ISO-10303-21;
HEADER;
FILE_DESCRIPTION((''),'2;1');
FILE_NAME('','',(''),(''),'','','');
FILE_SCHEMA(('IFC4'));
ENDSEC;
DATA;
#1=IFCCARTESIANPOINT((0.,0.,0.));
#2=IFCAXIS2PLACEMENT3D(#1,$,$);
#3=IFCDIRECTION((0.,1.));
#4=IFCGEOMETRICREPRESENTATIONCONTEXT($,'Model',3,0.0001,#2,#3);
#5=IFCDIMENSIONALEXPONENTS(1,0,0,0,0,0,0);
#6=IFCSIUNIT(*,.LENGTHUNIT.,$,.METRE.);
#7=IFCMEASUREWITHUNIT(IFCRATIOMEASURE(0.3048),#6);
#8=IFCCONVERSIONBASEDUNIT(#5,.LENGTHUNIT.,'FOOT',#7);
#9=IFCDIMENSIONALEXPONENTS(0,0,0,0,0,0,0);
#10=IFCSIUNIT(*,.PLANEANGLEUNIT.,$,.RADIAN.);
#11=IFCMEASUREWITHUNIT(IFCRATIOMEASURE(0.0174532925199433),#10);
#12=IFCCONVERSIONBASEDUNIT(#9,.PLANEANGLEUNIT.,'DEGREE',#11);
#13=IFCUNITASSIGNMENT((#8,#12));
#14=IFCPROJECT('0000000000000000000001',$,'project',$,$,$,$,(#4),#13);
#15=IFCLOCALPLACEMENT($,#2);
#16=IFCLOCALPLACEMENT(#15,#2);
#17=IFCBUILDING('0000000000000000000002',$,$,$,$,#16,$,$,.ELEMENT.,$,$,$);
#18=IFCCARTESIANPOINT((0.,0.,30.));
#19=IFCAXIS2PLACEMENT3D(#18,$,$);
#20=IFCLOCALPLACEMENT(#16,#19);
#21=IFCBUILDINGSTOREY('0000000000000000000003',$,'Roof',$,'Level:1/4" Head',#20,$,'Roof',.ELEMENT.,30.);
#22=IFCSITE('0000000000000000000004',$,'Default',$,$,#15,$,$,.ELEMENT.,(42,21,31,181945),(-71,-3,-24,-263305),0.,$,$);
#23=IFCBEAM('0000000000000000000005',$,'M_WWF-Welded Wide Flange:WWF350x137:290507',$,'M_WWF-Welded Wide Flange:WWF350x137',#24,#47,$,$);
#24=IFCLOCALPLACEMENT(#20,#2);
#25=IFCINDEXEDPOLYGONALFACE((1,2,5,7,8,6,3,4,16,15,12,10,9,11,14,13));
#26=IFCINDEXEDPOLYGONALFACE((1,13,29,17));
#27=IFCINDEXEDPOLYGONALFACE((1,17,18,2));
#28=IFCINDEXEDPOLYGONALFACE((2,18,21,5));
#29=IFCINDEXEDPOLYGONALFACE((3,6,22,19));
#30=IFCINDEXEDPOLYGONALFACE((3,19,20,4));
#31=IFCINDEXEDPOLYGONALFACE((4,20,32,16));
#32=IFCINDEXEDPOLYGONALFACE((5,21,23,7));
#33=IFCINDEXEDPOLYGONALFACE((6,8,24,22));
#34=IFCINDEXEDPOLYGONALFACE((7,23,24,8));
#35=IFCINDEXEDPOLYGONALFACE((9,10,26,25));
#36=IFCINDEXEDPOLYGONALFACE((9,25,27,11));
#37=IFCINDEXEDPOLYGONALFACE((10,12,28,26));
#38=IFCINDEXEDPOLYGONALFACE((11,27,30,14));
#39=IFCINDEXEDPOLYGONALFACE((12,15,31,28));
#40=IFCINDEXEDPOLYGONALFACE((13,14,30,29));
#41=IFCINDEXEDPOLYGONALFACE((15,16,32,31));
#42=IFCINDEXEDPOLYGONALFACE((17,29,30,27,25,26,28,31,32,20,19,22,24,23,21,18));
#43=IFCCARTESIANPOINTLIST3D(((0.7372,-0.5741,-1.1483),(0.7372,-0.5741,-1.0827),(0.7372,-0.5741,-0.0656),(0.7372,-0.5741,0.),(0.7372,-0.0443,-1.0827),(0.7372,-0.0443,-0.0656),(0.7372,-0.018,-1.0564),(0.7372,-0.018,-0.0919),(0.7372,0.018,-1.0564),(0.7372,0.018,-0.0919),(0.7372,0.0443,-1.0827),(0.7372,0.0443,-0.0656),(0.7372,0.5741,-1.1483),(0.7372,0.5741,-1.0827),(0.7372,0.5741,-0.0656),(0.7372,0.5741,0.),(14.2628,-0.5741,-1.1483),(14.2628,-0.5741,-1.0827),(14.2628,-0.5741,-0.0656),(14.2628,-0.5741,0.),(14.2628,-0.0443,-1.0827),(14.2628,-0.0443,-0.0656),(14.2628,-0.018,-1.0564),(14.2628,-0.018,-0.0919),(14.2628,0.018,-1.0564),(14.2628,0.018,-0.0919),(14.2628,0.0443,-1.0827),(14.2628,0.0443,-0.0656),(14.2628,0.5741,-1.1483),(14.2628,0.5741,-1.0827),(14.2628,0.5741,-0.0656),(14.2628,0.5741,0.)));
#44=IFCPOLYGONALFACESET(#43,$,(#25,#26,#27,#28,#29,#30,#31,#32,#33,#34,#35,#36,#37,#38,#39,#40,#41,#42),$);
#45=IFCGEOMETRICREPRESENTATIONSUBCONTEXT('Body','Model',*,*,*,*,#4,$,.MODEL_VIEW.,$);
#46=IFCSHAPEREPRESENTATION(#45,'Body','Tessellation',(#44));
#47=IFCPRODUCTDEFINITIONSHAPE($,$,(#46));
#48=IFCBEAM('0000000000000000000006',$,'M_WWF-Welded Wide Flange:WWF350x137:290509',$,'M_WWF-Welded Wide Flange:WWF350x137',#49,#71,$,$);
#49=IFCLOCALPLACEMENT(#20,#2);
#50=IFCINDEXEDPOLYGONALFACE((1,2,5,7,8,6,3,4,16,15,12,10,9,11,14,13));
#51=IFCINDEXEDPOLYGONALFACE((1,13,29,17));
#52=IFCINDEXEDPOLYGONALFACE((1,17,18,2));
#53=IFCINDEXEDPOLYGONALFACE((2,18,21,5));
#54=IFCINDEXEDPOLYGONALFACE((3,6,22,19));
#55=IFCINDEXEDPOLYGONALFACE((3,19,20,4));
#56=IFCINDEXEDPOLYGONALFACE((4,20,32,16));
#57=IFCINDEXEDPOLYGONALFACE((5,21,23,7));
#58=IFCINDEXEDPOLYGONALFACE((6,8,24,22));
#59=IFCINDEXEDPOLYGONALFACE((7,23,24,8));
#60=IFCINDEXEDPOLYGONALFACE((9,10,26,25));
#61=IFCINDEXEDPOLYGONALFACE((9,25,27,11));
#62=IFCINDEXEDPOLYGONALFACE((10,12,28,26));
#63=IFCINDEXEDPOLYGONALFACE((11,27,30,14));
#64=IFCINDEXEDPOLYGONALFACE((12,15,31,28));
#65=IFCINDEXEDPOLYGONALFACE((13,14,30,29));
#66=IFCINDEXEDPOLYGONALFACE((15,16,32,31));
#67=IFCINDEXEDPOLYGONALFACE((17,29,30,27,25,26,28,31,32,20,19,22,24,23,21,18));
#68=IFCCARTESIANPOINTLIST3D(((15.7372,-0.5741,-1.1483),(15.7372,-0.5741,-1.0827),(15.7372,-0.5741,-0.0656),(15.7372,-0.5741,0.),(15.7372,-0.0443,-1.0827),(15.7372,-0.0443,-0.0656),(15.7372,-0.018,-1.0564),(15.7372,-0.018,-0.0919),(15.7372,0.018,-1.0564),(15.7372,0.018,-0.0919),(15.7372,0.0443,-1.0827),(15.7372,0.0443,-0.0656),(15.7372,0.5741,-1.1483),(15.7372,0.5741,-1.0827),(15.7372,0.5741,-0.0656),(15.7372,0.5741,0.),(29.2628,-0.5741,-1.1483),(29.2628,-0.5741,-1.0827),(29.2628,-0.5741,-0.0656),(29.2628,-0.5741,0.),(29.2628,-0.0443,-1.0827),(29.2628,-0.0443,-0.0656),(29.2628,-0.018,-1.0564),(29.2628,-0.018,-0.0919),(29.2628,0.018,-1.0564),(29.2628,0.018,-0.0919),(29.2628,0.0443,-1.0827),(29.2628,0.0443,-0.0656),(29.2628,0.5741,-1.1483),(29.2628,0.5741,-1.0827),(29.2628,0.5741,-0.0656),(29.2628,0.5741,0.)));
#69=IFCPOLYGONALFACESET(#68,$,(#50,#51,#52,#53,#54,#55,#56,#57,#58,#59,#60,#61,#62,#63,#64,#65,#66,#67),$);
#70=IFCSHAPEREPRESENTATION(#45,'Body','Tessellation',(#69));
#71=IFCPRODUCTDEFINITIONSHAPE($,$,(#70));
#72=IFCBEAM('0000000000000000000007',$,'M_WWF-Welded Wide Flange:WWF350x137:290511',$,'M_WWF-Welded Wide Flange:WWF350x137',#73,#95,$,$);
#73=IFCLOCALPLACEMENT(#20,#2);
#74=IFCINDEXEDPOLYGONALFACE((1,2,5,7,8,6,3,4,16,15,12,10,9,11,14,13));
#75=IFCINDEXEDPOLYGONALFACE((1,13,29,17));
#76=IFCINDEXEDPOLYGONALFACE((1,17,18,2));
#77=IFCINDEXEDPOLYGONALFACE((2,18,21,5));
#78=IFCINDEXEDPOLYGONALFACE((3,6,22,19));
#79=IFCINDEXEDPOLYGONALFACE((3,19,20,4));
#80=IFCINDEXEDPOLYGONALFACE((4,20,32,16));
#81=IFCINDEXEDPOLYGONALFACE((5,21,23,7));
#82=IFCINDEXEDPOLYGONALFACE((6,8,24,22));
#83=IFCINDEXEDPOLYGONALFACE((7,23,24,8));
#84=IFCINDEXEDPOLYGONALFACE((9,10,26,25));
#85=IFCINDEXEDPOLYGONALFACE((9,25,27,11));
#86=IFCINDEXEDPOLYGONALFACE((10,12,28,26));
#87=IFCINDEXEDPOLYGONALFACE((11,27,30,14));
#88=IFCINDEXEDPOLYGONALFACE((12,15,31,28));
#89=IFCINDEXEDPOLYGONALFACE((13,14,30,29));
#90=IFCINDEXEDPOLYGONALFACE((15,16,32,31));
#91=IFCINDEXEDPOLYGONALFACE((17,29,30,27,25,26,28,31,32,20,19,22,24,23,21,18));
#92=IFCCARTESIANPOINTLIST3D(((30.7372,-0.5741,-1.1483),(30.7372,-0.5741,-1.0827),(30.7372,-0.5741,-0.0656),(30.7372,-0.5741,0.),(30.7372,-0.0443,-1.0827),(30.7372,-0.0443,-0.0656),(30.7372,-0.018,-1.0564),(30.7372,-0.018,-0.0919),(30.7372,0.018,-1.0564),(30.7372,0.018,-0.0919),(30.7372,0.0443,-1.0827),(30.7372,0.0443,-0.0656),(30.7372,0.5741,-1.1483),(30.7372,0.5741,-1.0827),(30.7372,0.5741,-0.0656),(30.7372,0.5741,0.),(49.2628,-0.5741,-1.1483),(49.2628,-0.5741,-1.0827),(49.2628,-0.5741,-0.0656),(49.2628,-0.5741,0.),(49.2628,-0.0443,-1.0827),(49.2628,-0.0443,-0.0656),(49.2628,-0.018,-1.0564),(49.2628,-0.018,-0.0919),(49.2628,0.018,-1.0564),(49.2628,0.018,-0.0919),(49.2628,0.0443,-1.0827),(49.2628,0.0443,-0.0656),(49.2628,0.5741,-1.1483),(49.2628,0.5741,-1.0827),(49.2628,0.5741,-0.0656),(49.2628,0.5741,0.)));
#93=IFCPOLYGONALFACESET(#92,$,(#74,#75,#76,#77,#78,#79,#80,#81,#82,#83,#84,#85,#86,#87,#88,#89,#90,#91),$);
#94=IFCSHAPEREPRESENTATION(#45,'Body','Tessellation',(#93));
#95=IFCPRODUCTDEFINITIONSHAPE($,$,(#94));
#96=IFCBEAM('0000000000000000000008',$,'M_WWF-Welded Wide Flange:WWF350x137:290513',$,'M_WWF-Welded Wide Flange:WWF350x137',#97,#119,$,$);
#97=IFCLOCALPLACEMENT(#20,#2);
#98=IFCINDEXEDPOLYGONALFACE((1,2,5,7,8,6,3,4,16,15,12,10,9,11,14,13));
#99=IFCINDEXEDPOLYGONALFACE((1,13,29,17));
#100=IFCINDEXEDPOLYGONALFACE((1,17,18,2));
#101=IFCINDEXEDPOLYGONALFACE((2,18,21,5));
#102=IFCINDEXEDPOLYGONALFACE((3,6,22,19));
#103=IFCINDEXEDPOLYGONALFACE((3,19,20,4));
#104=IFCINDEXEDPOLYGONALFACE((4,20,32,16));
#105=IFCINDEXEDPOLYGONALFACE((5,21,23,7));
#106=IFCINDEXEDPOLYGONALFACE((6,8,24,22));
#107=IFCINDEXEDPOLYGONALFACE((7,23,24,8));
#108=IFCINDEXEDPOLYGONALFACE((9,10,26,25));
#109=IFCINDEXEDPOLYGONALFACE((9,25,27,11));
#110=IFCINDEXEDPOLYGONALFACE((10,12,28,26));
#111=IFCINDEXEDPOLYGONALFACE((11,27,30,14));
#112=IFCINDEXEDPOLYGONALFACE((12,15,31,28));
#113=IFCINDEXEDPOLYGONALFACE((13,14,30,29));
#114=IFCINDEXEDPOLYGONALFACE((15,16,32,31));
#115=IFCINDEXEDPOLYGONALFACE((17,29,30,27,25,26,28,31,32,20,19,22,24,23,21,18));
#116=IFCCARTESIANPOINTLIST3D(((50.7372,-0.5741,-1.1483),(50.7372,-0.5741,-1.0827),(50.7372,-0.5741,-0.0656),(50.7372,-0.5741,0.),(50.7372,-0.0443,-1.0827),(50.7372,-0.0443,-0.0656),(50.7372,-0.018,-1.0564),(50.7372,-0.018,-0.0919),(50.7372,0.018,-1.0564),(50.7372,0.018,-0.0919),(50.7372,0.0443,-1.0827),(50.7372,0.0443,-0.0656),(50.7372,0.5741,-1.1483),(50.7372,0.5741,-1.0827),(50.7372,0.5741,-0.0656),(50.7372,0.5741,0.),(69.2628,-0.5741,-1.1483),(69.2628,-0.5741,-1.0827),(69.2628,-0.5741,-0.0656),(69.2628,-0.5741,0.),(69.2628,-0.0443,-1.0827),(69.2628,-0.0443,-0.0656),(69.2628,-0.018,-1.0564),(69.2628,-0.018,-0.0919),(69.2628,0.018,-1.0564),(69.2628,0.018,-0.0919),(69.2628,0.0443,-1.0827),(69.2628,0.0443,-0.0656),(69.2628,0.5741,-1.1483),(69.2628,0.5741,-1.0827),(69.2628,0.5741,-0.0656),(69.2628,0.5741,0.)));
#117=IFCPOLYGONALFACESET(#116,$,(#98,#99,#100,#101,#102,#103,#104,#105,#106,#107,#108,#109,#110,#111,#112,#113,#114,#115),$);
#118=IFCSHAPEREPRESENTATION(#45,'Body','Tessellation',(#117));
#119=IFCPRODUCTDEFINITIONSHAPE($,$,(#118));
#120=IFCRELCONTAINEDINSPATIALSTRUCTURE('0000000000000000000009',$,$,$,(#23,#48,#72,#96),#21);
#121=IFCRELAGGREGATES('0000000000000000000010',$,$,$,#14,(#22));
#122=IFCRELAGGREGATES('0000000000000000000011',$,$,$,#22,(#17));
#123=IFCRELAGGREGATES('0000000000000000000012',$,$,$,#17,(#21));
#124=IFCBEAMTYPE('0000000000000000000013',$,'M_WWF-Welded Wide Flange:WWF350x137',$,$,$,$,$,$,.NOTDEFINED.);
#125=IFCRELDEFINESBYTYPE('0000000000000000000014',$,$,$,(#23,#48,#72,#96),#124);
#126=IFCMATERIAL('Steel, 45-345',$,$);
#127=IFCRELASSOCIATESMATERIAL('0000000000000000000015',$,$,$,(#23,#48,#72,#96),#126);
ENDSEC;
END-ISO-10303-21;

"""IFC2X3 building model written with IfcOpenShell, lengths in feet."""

from ifc_helpers import new_model, entity, si_unit, converted_unit, direction, frame, origin, place, context, subcontext, project, spatial, polyline, outline, extrude, material, type_object, element, save


model = new_model("IFC2X3")

# Units and contexts
model_context = context("Model", 3, precision=0.0001, world=origin(), true_north=direction((0.0, 1.0)))
body_context = subcontext(model_context, "Body", "Model", "MODEL_VIEW")
ifc_project = project(units=[converted_unit("LENGTHUNIT", "FOOT", entity("IfcRatioMeasure", 0.3048), si_unit("LENGTHUNIT", "METRE"), dimensions=[1, 0, 0, 0, 0, 0, 0]), converted_unit("PLANEANGLEUNIT", "DEGREE", entity("IfcRatioMeasure", 0.0174532925199433), si_unit("PLANEANGLEUNIT", "RADIAN"), dimensions=[0, 0, 0, 0, 0, 0, 0])], contexts=[model_context])

# Site, building, storey
site_placement = place(None, origin())
site = spatial("IfcSite", under=ifc_project, at=site_placement, Name="Default", CompositionType="ELEMENT", RefLatitude=(42, 21, 31, 181945), RefLongitude=(-71, -3, -24, -263305), RefElevation=0.0)
building_placement = place(site_placement, origin())
building = spatial("IfcBuilding", under=site, at=building_placement, CompositionType="ELEMENT")
storey_placement = place(building_placement, frame((0.0, 0.0, 30.0)))
storey = spatial("IfcBuildingStorey", under=building, at=storey_placement, Name="Roof", ObjectType="Level:1/4\" Head", LongName="Roof", CompositionType="ELEMENT", Elevation=30.0)

# Beams
ifc_material = material(Name="Steel, 45-345")
beam_type = type_object("IfcBeamType", Name="M_WWF-Welded Wide Flange:WWF350x137", PredefinedType="NOTDEFINED")
beam_1_placement = place(storey_placement, origin())
element("IfcBeam", 1, at=beam_1_placement, inside=storey, type_object=beam_type, material=ifc_material, Name="M_WWF-Welded Wide Flange:WWF350x137:290507", ObjectType="M_WWF-Welded Wide Flange:WWF350x137", context=body_context, shape_type="SweptSolid", body=[
    extrude(outline(polyline([(-0.5741, -0.5741), (-0.5085, -0.5741), (-0.5085, -0.0443), (-0.4823, -0.018), (0.4823, -0.018), (0.5085, -0.0443), (0.5085, -0.5741), (0.5741, -0.5741), (0.5741, 0.5741), (0.5085, 0.5741), (0.5085, 0.0443), (0.4823, 0.018), (-0.4823, 0.018), (-0.5085, 0.0443), (-0.5085, 0.5741), (-0.5741, 0.5741), (-0.5741, -0.5741)])), frame((0.7372, 0.0, -0.5741), z_axis=(1.0, 0.0, 0.0), x_axis=(0.0, 0.0, -1.0)), (0.0, 0.0, 1.0), 13.5256),
])
beam_2_placement = place(storey_placement, frame((15.0, 0.0, 0.0)))
element("IfcBeam", 2, at=beam_2_placement, inside=storey, type_object=beam_type, material=ifc_material, Name="M_WWF-Welded Wide Flange:WWF350x137:290509", ObjectType="M_WWF-Welded Wide Flange:WWF350x137", context=body_context, shape_type="SweptSolid", body=[
    extrude(outline(polyline([(-0.5741, -0.5741), (-0.5085, -0.5741), (-0.5085, -0.0443), (-0.4823, -0.018), (0.4823, -0.018), (0.5085, -0.0443), (0.5085, -0.5741), (0.5741, -0.5741), (0.5741, 0.5741), (0.5085, 0.5741), (0.5085, 0.0443), (0.4823, 0.018), (-0.4823, 0.018), (-0.5085, 0.0443), (-0.5085, 0.5741), (-0.5741, 0.5741), (-0.5741, -0.5741)])), frame((0.7372, 0.0, -0.5741), z_axis=(1.0, 0.0, 0.0), x_axis=(0.0, 0.0, -1.0)), (0.0, 0.0, 1.0), 13.5256),
])
beam_3_placement = place(storey_placement, frame((30.0, 0.0, 0.0)))
element("IfcBeam", 3, at=beam_3_placement, inside=storey, type_object=beam_type, material=ifc_material, Name="M_WWF-Welded Wide Flange:WWF350x137:290511", ObjectType="M_WWF-Welded Wide Flange:WWF350x137", context=body_context, shape_type="SweptSolid", body=[
    extrude(outline(polyline([(-0.5741, -0.5741), (-0.5085, -0.5741), (-0.5085, -0.0443), (-0.4823, -0.018), (0.4823, -0.018), (0.5085, -0.0443), (0.5085, -0.5741), (0.5741, -0.5741), (0.5741, 0.5741), (0.5085, 0.5741), (0.5085, 0.0443), (0.4823, 0.018), (-0.4823, 0.018), (-0.5085, 0.0443), (-0.5085, 0.5741), (-0.5741, 0.5741), (-0.5741, -0.5741)])), frame((0.7372, 0.0, -0.5741), z_axis=(1.0, 0.0, 0.0), x_axis=(0.0, 0.0, -1.0)), (0.0, 0.0, 1.0), 18.5256),
])
beam_4_placement = place(storey_placement, frame((50.0, 0.0, 0.0)))
element("IfcBeam", 4, at=beam_4_placement, inside=storey, type_object=beam_type, material=ifc_material, Name="M_WWF-Welded Wide Flange:WWF350x137:290513", ObjectType="M_WWF-Welded Wide Flange:WWF350x137", context=body_context, shape_type="SweptSolid", body=[
    extrude(outline(polyline([(-0.5741, -0.5741), (-0.5085, -0.5741), (-0.5085, -0.0443), (-0.4823, -0.018), (0.4823, -0.018), (0.5085, -0.0443), (0.5085, -0.5741), (0.5741, -0.5741), (0.5741, 0.5741), (0.5085, 0.5741), (0.5085, 0.0443), (0.4823, 0.018), (-0.4823, 0.018), (-0.5085, 0.0443), (-0.5085, 0.5741), (-0.5741, 0.5741), (-0.5741, -0.5741)])), frame((0.7372, 0.0, -0.5741), z_axis=(1.0, 0.0, 0.0), x_axis=(0.0, 0.0, -1.0)), (0.0, 0.0, 1.0), 18.5256),
])

save(model, "model.ifc")
